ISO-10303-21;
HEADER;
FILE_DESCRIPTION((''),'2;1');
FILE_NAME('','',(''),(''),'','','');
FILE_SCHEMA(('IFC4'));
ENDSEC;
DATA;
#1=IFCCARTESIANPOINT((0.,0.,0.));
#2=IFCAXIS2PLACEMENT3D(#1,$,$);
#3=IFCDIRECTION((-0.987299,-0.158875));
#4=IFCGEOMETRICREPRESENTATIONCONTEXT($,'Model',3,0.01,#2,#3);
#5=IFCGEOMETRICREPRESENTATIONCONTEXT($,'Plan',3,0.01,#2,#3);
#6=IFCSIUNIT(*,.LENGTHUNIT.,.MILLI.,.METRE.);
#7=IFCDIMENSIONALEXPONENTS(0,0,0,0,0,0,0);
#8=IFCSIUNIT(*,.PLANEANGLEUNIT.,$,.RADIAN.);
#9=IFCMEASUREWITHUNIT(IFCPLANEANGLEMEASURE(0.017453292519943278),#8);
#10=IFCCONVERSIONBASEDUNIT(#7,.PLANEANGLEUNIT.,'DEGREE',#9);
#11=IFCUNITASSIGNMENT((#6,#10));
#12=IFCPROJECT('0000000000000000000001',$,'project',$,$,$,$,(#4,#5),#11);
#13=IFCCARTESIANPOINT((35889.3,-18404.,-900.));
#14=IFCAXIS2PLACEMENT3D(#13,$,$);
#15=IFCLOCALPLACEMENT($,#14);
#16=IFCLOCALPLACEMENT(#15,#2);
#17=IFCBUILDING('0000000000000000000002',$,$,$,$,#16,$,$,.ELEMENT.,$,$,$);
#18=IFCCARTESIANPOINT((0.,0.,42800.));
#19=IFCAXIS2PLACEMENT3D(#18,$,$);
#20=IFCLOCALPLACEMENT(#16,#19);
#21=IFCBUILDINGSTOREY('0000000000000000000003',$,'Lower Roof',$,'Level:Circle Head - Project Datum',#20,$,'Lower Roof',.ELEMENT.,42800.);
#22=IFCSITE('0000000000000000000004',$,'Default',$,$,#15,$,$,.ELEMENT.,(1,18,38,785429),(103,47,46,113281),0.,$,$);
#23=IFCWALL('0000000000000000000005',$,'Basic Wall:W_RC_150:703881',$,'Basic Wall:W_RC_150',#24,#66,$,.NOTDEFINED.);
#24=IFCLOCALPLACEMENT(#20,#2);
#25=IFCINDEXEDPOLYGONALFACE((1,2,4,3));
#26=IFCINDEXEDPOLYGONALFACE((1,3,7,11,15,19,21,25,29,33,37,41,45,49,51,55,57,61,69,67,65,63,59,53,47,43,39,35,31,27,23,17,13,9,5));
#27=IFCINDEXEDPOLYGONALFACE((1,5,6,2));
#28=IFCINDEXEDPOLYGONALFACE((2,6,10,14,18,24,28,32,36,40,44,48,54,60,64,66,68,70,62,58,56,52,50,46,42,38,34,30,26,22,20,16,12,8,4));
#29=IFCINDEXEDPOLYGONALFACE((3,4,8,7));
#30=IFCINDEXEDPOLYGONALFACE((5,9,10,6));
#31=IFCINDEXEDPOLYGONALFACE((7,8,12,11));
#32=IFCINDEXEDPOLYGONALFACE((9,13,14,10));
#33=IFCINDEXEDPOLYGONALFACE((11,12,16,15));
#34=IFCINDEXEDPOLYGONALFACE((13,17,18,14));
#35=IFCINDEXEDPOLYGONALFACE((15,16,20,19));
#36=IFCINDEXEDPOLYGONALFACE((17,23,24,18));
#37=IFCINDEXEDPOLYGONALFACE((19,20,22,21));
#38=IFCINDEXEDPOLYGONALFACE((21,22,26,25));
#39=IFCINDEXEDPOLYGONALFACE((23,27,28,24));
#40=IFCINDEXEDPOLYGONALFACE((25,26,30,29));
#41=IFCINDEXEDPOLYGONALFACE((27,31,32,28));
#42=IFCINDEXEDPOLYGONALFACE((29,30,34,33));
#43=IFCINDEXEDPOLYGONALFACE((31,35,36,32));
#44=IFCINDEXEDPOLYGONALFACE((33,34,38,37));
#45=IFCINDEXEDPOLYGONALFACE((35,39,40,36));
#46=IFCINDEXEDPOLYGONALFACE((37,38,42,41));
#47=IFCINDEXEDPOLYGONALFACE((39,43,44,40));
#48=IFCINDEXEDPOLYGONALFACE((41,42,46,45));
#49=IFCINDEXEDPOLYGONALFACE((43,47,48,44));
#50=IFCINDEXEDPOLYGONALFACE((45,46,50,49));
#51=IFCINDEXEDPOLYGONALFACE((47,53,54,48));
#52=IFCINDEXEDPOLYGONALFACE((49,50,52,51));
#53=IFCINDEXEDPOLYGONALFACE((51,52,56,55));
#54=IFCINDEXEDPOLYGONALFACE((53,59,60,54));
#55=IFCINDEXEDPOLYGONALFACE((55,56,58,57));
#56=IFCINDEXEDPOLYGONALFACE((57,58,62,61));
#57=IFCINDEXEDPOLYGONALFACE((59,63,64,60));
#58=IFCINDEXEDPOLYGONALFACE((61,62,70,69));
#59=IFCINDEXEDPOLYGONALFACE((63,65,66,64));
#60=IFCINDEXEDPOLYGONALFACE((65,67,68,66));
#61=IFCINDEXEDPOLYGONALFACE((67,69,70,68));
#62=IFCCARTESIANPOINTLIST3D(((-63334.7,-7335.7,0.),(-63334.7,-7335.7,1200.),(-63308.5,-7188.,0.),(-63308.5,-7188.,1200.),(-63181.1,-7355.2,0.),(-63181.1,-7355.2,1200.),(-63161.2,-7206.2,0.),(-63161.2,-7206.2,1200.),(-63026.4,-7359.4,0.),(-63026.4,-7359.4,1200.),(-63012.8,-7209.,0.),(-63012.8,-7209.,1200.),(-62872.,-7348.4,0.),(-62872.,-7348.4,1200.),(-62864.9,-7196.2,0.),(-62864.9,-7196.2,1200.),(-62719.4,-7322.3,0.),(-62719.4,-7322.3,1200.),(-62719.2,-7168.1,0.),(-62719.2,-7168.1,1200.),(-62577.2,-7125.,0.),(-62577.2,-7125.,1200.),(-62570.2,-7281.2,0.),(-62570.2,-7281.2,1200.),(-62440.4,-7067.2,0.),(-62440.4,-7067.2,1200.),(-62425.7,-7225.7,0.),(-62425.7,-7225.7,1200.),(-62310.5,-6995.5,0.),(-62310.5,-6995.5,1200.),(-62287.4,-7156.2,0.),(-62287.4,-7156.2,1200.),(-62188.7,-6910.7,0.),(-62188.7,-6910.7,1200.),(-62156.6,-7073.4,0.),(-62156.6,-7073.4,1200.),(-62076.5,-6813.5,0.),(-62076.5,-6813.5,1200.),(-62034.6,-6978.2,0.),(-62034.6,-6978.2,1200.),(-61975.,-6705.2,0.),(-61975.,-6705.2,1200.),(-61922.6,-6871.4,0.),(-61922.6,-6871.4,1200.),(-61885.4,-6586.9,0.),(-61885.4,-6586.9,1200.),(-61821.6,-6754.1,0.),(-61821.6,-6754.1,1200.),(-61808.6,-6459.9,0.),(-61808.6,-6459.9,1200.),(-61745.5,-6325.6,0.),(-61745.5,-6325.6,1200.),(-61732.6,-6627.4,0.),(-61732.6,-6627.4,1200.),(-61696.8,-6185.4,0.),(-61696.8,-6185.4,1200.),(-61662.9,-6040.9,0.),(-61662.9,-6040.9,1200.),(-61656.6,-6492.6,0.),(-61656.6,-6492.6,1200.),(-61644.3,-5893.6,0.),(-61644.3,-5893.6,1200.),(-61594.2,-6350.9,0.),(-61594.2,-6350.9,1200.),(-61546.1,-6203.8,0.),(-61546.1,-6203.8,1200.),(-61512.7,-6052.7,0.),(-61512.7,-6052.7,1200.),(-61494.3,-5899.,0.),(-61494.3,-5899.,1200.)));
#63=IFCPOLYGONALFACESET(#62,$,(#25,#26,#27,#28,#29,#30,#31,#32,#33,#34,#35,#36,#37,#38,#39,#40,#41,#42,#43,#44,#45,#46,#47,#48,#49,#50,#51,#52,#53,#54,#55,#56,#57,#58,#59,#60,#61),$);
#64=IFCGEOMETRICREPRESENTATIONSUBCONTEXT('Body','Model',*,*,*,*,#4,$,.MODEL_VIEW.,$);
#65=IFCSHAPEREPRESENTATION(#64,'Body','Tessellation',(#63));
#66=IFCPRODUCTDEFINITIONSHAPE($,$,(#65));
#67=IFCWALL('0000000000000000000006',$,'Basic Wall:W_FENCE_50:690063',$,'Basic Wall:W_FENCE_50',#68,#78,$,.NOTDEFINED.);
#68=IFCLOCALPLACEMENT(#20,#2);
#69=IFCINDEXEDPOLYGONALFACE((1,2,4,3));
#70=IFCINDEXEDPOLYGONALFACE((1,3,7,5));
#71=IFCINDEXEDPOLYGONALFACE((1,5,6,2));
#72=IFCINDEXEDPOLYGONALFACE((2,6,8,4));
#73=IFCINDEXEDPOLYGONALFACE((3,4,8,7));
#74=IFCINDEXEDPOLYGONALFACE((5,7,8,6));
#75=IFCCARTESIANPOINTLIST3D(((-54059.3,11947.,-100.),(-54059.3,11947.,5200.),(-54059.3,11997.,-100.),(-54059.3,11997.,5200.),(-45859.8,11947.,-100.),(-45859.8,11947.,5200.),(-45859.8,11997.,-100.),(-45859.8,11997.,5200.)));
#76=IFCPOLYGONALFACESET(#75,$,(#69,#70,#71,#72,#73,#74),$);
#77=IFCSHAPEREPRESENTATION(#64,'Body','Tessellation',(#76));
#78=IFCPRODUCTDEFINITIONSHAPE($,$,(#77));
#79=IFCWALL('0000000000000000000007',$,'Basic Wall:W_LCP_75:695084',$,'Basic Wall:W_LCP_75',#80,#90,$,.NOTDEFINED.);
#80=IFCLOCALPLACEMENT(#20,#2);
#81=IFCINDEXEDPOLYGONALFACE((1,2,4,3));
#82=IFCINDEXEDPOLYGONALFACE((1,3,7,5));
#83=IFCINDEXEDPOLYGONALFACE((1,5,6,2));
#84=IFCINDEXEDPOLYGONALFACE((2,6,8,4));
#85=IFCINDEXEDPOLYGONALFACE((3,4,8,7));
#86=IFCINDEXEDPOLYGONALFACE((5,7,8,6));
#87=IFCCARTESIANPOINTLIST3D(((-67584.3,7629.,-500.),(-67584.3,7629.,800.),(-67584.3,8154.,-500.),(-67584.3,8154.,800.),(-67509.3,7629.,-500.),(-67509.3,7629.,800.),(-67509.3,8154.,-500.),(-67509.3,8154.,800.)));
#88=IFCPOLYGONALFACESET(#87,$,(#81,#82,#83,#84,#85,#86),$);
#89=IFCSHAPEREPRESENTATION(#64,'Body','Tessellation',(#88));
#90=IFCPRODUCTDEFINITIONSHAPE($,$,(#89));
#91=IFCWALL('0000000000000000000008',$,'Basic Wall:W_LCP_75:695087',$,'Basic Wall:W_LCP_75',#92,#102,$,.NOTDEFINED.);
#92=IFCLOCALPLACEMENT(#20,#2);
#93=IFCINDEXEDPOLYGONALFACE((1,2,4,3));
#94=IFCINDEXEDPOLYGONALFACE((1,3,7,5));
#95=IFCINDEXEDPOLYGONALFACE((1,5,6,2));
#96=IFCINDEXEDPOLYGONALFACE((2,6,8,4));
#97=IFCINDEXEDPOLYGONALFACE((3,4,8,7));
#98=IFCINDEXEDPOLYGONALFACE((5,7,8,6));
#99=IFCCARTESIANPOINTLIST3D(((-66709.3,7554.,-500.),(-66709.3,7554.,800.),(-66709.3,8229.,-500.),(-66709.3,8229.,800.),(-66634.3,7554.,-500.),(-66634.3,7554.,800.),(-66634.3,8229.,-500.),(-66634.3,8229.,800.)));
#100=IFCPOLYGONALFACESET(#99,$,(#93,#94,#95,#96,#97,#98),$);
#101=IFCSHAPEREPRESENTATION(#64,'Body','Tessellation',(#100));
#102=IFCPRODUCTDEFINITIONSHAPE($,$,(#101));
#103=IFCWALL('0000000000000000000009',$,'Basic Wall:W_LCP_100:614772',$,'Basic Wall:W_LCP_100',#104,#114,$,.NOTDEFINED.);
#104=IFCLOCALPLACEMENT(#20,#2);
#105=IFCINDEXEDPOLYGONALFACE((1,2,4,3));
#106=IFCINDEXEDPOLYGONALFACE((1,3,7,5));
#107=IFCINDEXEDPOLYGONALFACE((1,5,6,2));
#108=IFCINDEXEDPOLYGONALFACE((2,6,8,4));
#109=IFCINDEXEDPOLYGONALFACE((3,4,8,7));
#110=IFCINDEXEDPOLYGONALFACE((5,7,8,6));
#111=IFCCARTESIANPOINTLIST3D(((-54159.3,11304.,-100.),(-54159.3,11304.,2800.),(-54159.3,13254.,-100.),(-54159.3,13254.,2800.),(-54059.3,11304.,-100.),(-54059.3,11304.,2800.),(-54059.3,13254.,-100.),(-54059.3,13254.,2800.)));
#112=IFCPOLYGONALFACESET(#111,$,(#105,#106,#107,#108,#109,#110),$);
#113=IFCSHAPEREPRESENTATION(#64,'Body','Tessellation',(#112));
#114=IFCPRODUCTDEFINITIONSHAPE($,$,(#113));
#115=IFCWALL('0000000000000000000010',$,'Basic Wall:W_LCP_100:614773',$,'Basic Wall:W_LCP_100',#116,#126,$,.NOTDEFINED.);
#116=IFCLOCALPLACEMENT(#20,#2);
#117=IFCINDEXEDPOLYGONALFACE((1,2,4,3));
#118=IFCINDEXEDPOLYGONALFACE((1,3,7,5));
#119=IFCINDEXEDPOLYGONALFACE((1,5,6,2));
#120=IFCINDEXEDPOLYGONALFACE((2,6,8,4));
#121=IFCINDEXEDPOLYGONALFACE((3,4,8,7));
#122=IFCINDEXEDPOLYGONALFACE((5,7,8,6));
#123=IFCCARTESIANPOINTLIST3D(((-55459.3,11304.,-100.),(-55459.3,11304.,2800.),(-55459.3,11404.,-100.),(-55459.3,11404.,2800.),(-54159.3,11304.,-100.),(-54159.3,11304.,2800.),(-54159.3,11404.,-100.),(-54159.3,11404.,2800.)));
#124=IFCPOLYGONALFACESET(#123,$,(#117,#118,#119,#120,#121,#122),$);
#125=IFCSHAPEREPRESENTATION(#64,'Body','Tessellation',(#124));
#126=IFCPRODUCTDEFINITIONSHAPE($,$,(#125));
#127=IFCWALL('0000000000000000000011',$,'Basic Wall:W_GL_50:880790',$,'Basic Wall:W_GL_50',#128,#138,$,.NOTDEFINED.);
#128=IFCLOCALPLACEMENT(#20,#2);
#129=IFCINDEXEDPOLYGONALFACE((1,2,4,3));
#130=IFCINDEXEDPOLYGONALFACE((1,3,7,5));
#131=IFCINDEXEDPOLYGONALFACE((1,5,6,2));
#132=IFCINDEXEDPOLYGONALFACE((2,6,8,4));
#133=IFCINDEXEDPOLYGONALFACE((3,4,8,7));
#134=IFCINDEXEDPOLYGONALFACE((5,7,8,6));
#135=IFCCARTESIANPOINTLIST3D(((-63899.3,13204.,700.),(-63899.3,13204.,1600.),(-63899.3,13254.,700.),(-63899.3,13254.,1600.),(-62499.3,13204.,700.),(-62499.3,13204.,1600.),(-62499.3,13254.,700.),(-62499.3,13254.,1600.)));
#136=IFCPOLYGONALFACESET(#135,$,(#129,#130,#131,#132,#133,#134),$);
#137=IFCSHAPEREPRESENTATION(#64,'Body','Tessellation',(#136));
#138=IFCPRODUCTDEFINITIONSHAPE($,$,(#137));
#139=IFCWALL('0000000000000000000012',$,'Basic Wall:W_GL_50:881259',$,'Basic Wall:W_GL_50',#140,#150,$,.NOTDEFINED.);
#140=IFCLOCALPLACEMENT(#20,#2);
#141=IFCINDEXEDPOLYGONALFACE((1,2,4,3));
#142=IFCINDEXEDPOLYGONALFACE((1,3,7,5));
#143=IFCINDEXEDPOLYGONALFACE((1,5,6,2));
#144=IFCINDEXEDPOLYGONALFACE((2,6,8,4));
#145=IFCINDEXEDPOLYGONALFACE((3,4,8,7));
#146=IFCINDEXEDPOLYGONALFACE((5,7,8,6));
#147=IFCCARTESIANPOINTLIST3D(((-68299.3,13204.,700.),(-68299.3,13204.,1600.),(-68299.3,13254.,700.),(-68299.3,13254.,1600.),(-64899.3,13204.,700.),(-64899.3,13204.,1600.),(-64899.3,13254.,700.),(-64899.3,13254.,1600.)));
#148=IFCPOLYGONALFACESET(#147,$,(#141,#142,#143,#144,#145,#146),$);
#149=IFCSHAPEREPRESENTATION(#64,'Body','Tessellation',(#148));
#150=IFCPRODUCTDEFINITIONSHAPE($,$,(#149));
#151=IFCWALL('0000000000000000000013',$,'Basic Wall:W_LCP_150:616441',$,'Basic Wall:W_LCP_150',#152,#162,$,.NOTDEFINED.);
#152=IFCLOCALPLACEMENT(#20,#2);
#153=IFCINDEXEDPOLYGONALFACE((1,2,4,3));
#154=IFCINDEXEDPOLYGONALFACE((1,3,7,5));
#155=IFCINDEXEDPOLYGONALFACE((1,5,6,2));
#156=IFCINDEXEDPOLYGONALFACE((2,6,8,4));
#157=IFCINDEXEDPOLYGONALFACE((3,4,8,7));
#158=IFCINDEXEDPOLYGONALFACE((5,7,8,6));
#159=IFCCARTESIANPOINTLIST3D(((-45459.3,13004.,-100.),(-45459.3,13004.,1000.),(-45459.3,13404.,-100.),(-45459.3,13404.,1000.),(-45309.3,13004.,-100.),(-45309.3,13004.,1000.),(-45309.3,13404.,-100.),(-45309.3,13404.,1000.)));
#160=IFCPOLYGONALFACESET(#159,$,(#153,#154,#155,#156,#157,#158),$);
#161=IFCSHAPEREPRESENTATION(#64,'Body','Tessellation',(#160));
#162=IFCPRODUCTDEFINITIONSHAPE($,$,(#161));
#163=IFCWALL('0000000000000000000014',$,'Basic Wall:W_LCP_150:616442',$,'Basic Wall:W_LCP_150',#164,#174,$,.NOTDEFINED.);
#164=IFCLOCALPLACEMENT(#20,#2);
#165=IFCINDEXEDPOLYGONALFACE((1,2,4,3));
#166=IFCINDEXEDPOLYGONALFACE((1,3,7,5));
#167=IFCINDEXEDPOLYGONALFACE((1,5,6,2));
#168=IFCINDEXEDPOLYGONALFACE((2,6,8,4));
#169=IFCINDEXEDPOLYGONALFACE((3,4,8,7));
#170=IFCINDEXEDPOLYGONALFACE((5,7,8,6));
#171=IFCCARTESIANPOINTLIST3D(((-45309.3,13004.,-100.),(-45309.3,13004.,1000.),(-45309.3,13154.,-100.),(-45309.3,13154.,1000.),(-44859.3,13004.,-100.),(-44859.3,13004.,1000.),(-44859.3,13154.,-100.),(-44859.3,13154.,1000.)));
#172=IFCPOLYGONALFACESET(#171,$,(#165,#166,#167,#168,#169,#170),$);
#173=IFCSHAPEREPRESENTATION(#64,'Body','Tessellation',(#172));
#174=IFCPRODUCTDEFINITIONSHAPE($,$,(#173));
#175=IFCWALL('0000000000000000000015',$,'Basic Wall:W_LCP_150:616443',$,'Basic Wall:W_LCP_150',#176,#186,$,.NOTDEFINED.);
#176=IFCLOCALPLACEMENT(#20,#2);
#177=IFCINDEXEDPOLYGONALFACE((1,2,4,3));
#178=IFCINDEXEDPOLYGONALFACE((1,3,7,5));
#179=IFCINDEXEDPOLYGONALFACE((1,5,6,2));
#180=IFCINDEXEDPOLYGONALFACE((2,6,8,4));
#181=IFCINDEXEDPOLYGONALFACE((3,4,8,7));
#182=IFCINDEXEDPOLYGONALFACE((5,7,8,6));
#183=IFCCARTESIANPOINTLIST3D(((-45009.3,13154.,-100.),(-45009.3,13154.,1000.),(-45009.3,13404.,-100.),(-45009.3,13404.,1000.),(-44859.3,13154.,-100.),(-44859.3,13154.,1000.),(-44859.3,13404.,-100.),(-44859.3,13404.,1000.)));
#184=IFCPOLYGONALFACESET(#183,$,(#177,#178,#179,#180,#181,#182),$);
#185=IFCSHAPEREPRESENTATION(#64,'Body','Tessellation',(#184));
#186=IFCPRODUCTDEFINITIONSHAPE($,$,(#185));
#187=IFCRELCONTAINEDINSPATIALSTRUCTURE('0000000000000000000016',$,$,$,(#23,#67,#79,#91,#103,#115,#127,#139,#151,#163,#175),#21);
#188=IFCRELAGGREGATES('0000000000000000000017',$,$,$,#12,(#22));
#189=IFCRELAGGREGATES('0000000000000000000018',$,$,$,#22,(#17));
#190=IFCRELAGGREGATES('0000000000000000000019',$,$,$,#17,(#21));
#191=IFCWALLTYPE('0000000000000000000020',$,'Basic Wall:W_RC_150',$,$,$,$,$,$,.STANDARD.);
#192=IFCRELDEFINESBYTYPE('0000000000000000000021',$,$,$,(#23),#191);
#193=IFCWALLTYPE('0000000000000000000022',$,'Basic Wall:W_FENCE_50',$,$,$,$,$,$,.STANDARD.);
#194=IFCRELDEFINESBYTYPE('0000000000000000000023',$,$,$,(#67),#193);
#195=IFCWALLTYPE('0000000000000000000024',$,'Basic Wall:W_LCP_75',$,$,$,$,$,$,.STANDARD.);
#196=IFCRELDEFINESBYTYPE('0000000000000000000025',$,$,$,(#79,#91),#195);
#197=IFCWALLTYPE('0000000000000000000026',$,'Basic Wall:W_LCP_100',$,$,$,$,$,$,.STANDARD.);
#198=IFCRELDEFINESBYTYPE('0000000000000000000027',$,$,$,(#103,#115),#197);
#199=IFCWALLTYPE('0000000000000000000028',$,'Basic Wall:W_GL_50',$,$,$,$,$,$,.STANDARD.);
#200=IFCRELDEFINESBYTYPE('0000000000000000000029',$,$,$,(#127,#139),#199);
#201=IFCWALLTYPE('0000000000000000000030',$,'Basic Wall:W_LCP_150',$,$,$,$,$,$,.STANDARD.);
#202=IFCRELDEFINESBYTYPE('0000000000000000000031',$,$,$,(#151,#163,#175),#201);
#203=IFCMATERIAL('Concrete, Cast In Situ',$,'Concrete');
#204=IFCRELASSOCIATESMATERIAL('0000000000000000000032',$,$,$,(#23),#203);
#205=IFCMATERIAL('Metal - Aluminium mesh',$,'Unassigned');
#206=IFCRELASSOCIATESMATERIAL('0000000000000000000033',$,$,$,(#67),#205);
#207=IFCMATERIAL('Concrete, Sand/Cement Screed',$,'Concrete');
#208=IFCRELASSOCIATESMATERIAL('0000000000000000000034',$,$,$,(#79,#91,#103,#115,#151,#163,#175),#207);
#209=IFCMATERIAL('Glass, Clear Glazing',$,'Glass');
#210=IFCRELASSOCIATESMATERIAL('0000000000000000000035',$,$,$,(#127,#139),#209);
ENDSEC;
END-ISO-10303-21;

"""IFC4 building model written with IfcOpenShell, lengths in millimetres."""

from ifc_helpers import new_model, entity, si_unit, converted_unit, direction, frame, origin, place, context, subcontext, project, spatial, line, arc, indexed_curve, outline, extrude, material, type_object, element, save


model = new_model("IFC4")

# Units and contexts
model_context = context("Model", 3, precision=0.01, world=origin(), true_north=direction((-0.987299, -0.158875)))
plan_context = context("Plan", 3, precision=0.01, world=origin(), true_north=direction((-0.987299, -0.158875)))
body_context = subcontext(model_context, "Body", "Model", "MODEL_VIEW")
ifc_project = project(units=[si_unit("LENGTHUNIT", "METRE", prefix="MILLI"), converted_unit("PLANEANGLEUNIT", "DEGREE", entity("IfcPlaneAngleMeasure", 0.017453292519943278), si_unit("PLANEANGLEUNIT", "RADIAN"), dimensions=[0, 0, 0, 0, 0, 0, 0])], contexts=[model_context, plan_context])

# Site, building, storey
site_placement = place(None, frame((35889.3, -18404.0, -900.0)))
site = spatial("IfcSite", under=ifc_project, at=site_placement, Name="Default", CompositionType="ELEMENT", RefLatitude=(1, 18, 38, 785429), RefLongitude=(103, 47, 46, 113281), RefElevation=0.0)
building_placement = place(site_placement, origin())
building = spatial("IfcBuilding", under=site, at=building_placement, CompositionType="ELEMENT")
storey_placement = place(building_placement, frame((0.0, 0.0, 42800.0)))
storey = spatial("IfcBuildingStorey", under=building, at=storey_placement, Name="Lower Roof", ObjectType="Level:Circle Head - Project Datum", LongName="Lower Roof", CompositionType="ELEMENT", Elevation=42800.0)

# Shared definitions
ifc_material_1 = material(Name="Concrete, Sand/Cement Screed", Category="Concrete")

# Walls
ifc_material_2 = material(Name="Concrete, Cast In Situ", Category="Concrete")
wall_type_1 = type_object("IfcWallType", Name="Basic Wall:W_RC_150", PredefinedType="STANDARD")
wall_1_placement = place(storey_placement, frame((-61569.2, -5893.8, 0.0)))
element("IfcWall", 1, at=wall_1_placement, inside=storey, type_object=wall_type_1, material=ifc_material_2, Name="Basic Wall:W_RC_150:703881", ObjectType="Basic Wall:W_RC_150", PredefinedType="NOTDEFINED", context=body_context, shape_type="SweptSolid", body=[
    extrude(outline(indexed_curve([(-1765.5, -1441.9), (-525.3, -1133.6), (74.8, -5.2), (-75.2, 0.1), (-619.6, -1016.9), (-1739.3, -1294.2)], segments=[arc(1, 2, 3), line(3, 4), arc(4, 5, 6), line(6, 1)], self_intersect=False)), origin(), (0.0, 0.0, 1.0), 1200.0),
])
ifc_material_3 = material(Name="Metal - Aluminium mesh", Category="Unassigned")
wall_type_2 = type_object("IfcWallType", Name="Basic Wall:W_FENCE_50", PredefinedType="STANDARD")
wall_2_placement = place(storey_placement, frame((-45859.8, 11972.0, -100.0), z_axis=(0.0, 0.0, 1.0), x_axis=(-1.0, 0.0, 0.0)))
element("IfcWall", 2, at=wall_2_placement, inside=storey, type_object=wall_type_2, material=ifc_material_3, Name="Basic Wall:W_FENCE_50:690063", ObjectType="Basic Wall:W_FENCE_50", PredefinedType="NOTDEFINED", context=body_context, shape_type="SweptSolid", body=[
    extrude(outline(indexed_curve([(8199.6, 25.0), (0.0, 25.0), (0.0, -25.0), (8199.6, -25.0), (8199.6, 25.0)], self_intersect=False)), origin(), (0.0, 0.0, 1.0), 5300.0),
])
wall_type_3 = type_object("IfcWallType", Name="Basic Wall:W_LCP_75", PredefinedType="STANDARD")
wall_3_placement = place(storey_placement, frame((-67546.8, 8154.0, -500.0), z_axis=(0.0, 0.0, 1.0), x_axis=(0.0, -1.0, 0.0)))
element("IfcWall", 3, at=wall_3_placement, inside=storey, type_object=wall_type_3, material=ifc_material_1, Name="Basic Wall:W_LCP_75:695084", ObjectType="Basic Wall:W_LCP_75", PredefinedType="NOTDEFINED", context=body_context, shape_type="SweptSolid", body=[
    extrude(outline(indexed_curve([(525.0, 37.5), (0.0, 37.5), (0.0, -37.5), (525.0, -37.5), (525.0, 37.5)], self_intersect=False)), origin(), (0.0, 0.0, 1.0), 1300.0),
])
wall_4_placement = place(storey_placement, frame((-66671.8, 8229.0, -500.0), z_axis=(0.0, 0.0, 1.0), x_axis=(0.0, -1.0, 0.0)))
element("IfcWall", 4, at=wall_4_placement, inside=storey, type_object=wall_type_3, material=ifc_material_1, Name="Basic Wall:W_LCP_75:695087", ObjectType="Basic Wall:W_LCP_75", PredefinedType="NOTDEFINED", context=body_context, shape_type="SweptSolid", body=[
    extrude(outline(indexed_curve([(675.0, 37.5), (0.0, 37.5), (0.0, -37.5), (675.0, -37.5), (675.0, 37.5)], self_intersect=False)), origin(), (0.0, 0.0, 1.0), 1300.0),
])
wall_type_4 = type_object("IfcWallType", Name="Basic Wall:W_LCP_100", PredefinedType="STANDARD")
wall_5_placement = place(storey_placement, frame((-54109.3, 11304.0, -100.0), z_axis=(0.0, 0.0, 1.0), x_axis=(0.0, 1.0, 0.0)))
element("IfcWall", 5, at=wall_5_placement, inside=storey, type_object=wall_type_4, material=ifc_material_1, Name="Basic Wall:W_LCP_100:614772", ObjectType="Basic Wall:W_LCP_100", PredefinedType="NOTDEFINED", context=body_context, shape_type="SweptSolid", body=[
    extrude(outline(indexed_curve([(1950.0, 50.0), (0.0, 50.0), (0.0, -50.0), (1950.0, -50.0), (1950.0, 50.0)], self_intersect=False)), origin(), (0.0, 0.0, 1.0), 2900.0),
])
wall_6_placement = place(storey_placement, frame((-55459.3, 11354.0, -100.0)))
element("IfcWall", 6, at=wall_6_placement, inside=storey, type_object=wall_type_4, material=ifc_material_1, Name="Basic Wall:W_LCP_100:614773", ObjectType="Basic Wall:W_LCP_100", PredefinedType="NOTDEFINED", context=body_context, shape_type="SweptSolid", body=[
    extrude(outline(indexed_curve([(1300.0, 50.0), (0.0, 50.0), (0.0, -50.0), (1300.0, -50.0), (1300.0, 50.0)], self_intersect=False)), origin(), (0.0, 0.0, 1.0), 2900.0),
])
ifc_material_4 = material(Name="Glass, Clear Glazing", Category="Glass")
wall_type_5 = type_object("IfcWallType", Name="Basic Wall:W_GL_50", PredefinedType="STANDARD")
wall_7_placement = place(storey_placement, frame((-63899.3, 13229.0, 700.0)))
element("IfcWall", 7, at=wall_7_placement, inside=storey, type_object=wall_type_5, material=ifc_material_4, Name="Basic Wall:W_GL_50:880790", ObjectType="Basic Wall:W_GL_50", PredefinedType="NOTDEFINED", context=body_context, shape_type="SweptSolid", body=[
    extrude(outline(indexed_curve([(1400.0, 25.0), (0.0, 25.0), (0.0, -25.0), (1400.0, -25.0), (1400.0, 25.0)], self_intersect=False)), origin(), (0.0, 0.0, 1.0), 900.0),
])
wall_8_placement = place(storey_placement, frame((-68299.3, 13229.0, 700.0)))
element("IfcWall", 8, at=wall_8_placement, inside=storey, type_object=wall_type_5, material=ifc_material_4, Name="Basic Wall:W_GL_50:881259", ObjectType="Basic Wall:W_GL_50", PredefinedType="NOTDEFINED", context=body_context, shape_type="SweptSolid", body=[
    extrude(outline(indexed_curve([(3400.0, 25.0), (0.0, 25.0), (0.0, -25.0), (3400.0, -25.0), (3400.0, 25.0)], self_intersect=False)), origin(), (0.0, 0.0, 1.0), 900.0),
])
wall_type_6 = type_object("IfcWallType", Name="Basic Wall:W_LCP_150", PredefinedType="STANDARD")
wall_9_placement = place(storey_placement, frame((-45384.3, 13404.0, -100.0), z_axis=(0.0, 0.0, 1.0), x_axis=(0.0, -1.0, 0.0)))
element("IfcWall", 9, at=wall_9_placement, inside=storey, type_object=wall_type_6, material=ifc_material_1, Name="Basic Wall:W_LCP_150:616441", ObjectType="Basic Wall:W_LCP_150", PredefinedType="NOTDEFINED", context=body_context, shape_type="SweptSolid", body=[
    extrude(outline(indexed_curve([(400.0, 75.0), (0.0, 75.0), (0.0, -75.0), (400.0, -75.0), (400.0, 75.0)], self_intersect=False)), origin(), (0.0, 0.0, 1.0), 1100.0),
])
wall_10_placement = place(storey_placement, frame((-45309.3, 13079.0, -100.0)))
element("IfcWall", 10, at=wall_10_placement, inside=storey, type_object=wall_type_6, material=ifc_material_1, Name="Basic Wall:W_LCP_150:616442", ObjectType="Basic Wall:W_LCP_150", PredefinedType="NOTDEFINED", context=body_context, shape_type="SweptSolid", body=[
    extrude(outline(indexed_curve([(450.0, 75.0), (0.0, 75.0), (0.0, -75.0), (450.0, -75.0), (450.0, 75.0)], self_intersect=False)), origin(), (0.0, 0.0, 1.0), 1100.0),
])
wall_11_placement = place(storey_placement, frame((-44934.3, 13404.0, -100.0), z_axis=(0.0, 0.0, 1.0), x_axis=(0.0, -1.0, 0.0)))
element("IfcWall", 11, at=wall_11_placement, inside=storey, type_object=wall_type_6, material=ifc_material_1, Name="Basic Wall:W_LCP_150:616443", ObjectType="Basic Wall:W_LCP_150", PredefinedType="NOTDEFINED", context=body_context, shape_type="SweptSolid", body=[
    extrude(outline(indexed_curve([(250.0, 75.0), (0.0, 75.0), (0.0, -75.0), (250.0, -75.0), (250.0, 75.0)], self_intersect=False)), origin(), (0.0, 0.0, 1.0), 1100.0),
])

save(model, "model.ifc")
